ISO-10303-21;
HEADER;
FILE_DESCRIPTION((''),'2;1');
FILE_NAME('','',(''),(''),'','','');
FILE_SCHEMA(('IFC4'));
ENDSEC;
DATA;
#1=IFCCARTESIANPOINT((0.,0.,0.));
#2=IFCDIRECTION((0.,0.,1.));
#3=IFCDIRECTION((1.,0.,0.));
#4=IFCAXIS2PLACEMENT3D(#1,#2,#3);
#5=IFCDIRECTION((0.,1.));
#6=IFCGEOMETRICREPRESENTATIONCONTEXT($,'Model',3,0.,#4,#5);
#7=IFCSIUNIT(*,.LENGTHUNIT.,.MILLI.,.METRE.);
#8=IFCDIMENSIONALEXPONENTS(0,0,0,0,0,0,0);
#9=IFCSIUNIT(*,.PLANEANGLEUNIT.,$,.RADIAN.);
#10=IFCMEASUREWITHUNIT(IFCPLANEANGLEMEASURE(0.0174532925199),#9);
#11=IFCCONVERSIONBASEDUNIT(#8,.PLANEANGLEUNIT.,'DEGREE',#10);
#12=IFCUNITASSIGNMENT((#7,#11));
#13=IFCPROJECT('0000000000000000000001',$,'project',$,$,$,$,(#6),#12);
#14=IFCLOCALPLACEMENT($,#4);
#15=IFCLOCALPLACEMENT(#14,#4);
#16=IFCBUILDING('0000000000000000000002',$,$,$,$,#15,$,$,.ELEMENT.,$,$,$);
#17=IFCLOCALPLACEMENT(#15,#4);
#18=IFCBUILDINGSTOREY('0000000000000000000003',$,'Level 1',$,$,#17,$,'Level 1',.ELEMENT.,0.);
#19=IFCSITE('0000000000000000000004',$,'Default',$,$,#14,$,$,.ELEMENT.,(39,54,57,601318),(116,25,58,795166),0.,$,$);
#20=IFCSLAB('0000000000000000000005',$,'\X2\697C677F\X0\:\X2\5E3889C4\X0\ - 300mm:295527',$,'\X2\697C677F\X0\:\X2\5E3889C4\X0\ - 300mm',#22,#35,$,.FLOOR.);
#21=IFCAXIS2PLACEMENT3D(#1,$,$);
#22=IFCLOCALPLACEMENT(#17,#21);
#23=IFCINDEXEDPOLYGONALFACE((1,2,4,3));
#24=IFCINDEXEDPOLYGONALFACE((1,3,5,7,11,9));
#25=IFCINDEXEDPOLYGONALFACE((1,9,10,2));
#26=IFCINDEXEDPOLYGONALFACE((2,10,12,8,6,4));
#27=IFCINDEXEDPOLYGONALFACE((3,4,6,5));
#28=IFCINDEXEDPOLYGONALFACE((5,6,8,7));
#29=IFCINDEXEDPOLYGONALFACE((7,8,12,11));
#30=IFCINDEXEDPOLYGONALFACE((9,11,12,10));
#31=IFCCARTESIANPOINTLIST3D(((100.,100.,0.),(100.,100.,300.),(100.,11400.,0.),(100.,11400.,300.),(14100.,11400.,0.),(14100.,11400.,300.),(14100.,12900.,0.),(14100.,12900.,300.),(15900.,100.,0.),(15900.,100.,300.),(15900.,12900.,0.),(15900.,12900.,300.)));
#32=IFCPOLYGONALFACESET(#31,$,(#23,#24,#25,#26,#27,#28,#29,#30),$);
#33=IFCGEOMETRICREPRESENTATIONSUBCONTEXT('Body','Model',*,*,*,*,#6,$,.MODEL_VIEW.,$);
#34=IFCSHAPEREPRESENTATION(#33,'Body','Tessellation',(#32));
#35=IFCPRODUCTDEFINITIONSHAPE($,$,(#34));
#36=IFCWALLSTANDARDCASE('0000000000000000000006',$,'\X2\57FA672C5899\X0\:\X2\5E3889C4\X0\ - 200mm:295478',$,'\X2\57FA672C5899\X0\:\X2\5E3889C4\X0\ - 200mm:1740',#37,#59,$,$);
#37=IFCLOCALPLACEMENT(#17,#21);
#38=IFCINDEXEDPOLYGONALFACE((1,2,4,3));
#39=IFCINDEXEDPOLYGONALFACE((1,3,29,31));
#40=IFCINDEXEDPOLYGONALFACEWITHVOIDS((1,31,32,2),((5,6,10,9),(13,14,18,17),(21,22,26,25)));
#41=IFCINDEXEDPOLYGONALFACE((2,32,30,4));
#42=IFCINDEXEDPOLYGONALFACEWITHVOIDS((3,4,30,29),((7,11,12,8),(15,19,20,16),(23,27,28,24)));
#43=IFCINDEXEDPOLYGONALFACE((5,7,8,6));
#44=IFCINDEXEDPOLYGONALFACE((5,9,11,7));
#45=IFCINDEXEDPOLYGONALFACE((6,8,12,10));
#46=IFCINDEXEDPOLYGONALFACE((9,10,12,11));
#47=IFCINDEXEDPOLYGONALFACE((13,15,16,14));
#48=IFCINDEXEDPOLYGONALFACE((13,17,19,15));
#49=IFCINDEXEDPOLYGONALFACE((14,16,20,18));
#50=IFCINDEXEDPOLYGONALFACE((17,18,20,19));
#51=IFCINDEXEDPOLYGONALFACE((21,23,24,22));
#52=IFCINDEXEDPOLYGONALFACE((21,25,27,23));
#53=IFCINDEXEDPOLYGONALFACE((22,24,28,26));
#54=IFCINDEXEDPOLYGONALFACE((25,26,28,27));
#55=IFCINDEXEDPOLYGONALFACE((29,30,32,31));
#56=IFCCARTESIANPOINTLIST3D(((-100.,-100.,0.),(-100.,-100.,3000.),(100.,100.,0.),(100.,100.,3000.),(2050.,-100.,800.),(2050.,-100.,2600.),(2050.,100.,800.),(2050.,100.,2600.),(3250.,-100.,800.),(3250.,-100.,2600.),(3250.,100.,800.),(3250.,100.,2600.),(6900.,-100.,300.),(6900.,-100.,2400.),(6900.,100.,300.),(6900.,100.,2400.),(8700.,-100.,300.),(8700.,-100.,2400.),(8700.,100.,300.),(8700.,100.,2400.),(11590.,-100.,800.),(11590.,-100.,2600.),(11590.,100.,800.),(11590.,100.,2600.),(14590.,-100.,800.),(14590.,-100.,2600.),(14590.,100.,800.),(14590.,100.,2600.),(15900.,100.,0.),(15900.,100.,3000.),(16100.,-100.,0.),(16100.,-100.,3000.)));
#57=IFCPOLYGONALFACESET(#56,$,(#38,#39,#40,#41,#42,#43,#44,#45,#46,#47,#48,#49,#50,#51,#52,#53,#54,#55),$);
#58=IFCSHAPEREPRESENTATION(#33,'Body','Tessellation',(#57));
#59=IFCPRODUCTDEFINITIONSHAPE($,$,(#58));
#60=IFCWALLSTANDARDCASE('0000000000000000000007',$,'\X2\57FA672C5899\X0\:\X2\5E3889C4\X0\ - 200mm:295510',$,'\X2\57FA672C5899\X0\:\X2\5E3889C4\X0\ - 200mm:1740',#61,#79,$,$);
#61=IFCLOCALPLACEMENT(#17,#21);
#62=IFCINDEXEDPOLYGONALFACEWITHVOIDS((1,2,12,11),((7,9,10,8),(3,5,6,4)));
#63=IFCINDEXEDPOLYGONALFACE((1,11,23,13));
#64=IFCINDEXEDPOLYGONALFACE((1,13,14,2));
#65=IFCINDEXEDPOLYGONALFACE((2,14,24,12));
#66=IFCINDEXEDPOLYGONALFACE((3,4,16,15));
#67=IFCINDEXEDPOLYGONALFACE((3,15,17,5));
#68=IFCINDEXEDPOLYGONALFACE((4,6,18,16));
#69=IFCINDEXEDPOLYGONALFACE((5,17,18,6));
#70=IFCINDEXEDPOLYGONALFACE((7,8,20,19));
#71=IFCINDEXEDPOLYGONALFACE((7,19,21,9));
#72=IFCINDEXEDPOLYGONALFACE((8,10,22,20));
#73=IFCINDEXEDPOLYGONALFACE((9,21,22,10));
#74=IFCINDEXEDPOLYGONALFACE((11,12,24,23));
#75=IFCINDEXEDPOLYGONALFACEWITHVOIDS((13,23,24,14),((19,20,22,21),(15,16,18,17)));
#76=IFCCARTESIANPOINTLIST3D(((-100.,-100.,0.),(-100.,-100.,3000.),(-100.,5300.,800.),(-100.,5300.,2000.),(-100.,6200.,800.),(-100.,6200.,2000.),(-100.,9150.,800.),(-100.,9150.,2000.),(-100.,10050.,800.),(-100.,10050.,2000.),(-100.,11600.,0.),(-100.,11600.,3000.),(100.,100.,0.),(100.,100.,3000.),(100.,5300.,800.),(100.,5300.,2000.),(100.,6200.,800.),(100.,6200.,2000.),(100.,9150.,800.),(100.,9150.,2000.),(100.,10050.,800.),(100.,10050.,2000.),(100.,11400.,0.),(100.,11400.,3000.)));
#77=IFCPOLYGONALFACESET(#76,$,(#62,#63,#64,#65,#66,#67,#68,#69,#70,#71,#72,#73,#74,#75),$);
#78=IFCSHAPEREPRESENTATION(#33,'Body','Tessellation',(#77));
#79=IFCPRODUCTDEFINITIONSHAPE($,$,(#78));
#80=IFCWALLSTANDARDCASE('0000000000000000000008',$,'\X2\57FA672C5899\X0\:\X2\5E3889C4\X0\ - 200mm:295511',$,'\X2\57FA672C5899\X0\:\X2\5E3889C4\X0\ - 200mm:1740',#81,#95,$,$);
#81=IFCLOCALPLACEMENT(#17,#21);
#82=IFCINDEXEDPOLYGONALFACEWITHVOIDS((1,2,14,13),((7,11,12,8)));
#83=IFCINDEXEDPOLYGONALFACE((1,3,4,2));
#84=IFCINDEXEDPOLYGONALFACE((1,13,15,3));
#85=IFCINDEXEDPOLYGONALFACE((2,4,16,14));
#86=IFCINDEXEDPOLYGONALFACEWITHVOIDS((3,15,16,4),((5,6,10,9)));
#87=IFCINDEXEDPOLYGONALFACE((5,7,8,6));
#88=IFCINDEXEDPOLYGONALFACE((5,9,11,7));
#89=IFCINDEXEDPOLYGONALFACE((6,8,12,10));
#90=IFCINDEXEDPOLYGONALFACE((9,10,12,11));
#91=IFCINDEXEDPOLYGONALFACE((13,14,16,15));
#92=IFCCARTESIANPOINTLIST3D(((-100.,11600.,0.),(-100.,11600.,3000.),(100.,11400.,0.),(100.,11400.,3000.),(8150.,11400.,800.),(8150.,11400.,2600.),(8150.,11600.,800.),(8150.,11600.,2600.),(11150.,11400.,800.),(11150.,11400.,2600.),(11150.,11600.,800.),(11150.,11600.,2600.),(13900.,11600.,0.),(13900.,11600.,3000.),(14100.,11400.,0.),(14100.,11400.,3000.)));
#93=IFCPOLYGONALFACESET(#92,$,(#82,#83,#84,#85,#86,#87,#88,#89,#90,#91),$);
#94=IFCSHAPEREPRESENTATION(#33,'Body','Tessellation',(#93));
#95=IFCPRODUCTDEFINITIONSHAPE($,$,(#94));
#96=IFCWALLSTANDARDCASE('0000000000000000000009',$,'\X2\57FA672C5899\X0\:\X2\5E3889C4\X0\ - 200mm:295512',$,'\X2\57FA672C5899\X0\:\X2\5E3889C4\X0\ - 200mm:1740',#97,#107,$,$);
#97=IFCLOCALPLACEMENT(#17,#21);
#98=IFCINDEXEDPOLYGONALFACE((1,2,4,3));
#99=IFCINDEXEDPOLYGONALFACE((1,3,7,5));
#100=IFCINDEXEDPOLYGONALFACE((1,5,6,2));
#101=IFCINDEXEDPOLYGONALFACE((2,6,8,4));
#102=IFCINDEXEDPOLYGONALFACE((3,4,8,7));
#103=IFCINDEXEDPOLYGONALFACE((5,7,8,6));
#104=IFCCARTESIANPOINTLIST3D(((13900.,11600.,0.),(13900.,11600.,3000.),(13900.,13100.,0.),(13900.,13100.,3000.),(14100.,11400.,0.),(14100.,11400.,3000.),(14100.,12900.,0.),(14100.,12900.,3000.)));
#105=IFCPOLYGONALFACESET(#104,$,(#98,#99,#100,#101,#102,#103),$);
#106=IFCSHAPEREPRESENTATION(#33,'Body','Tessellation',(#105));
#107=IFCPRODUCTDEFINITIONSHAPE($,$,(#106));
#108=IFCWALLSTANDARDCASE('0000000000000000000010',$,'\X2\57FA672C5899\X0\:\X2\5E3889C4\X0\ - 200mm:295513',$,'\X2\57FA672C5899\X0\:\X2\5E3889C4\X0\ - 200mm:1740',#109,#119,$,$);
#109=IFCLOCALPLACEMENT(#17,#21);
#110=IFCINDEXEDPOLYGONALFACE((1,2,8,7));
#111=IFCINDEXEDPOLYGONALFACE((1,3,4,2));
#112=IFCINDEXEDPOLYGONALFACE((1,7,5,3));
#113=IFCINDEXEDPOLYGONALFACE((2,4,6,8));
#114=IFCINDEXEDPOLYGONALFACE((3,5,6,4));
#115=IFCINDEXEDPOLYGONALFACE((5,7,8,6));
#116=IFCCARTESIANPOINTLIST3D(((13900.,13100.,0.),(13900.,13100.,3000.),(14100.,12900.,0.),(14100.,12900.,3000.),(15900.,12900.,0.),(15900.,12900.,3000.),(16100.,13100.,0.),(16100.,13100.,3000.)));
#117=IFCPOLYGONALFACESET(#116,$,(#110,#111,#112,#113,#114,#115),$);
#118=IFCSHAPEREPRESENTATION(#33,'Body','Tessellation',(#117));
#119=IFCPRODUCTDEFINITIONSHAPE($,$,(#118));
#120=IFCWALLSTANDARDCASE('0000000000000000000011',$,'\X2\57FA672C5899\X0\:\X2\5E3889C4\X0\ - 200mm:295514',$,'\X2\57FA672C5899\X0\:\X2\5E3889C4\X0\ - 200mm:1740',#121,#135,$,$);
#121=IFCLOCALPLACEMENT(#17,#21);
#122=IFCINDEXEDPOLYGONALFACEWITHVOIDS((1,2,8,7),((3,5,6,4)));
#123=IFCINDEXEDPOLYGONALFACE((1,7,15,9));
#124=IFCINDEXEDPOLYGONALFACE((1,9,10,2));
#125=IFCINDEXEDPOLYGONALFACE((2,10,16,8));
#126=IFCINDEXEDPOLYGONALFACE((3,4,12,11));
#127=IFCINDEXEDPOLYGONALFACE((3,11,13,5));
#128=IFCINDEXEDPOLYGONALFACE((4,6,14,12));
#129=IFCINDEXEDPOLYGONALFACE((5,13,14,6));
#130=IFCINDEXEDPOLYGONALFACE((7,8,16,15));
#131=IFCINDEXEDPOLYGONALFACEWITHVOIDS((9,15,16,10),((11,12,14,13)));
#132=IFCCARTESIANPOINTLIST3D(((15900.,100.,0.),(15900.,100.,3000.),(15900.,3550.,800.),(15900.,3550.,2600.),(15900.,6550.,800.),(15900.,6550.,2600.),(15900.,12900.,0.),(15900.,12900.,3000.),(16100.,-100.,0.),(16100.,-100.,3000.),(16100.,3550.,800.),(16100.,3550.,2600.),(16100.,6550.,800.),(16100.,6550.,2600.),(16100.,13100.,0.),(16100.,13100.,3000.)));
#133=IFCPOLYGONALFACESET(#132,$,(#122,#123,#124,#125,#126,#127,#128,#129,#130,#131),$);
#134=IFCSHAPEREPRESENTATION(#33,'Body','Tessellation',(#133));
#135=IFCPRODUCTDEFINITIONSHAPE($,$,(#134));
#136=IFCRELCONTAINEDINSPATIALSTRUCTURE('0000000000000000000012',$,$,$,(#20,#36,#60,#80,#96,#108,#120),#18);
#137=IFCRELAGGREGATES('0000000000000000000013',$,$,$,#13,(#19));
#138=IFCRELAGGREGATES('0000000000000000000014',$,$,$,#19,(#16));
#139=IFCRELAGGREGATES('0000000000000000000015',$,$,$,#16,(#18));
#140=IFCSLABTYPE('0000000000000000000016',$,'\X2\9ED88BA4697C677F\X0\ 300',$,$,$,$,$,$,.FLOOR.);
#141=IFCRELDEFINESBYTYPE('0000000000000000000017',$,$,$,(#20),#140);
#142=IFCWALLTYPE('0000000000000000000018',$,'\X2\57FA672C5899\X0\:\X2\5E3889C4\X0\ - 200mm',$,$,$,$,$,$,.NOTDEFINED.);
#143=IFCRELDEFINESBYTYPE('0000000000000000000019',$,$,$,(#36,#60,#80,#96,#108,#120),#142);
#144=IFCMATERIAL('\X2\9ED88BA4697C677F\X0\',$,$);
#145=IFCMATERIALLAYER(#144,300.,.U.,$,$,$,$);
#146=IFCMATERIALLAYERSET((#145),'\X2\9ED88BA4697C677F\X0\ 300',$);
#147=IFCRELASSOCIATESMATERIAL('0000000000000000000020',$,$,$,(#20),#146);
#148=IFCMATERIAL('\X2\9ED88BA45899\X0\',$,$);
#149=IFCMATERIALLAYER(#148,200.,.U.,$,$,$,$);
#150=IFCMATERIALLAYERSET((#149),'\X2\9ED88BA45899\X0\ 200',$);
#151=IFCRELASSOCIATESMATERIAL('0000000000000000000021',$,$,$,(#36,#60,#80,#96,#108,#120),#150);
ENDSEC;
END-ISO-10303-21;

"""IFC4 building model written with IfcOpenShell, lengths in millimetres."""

from ifc_helpers import new_model, entity, si_unit, converted_unit, direction, frame, origin_with_axes, place, context, subcontext, project, spatial, polyline, outline, extrude, material, layer, layer_set, layer_usage, type_object, element, save


model = new_model("IFC4")

# Units and contexts
model_context = context("Model", 3, precision=0.0, world=origin_with_axes(), true_north=direction((0.0, 1.0)))
body_context = subcontext(model_context, "Body", "Model", "MODEL_VIEW")
ifc_project = project(units=[si_unit("LENGTHUNIT", "METRE", prefix="MILLI"), converted_unit("PLANEANGLEUNIT", "DEGREE", entity("IfcPlaneAngleMeasure", 0.0174532925199), si_unit("PLANEANGLEUNIT", "RADIAN"), dimensions=[0, 0, 0, 0, 0, 0, 0])], contexts=[model_context])

# Site, building, storey
site_placement = place(None, origin_with_axes())
site = spatial("IfcSite", under=ifc_project, at=site_placement, Name="Default", CompositionType="ELEMENT", RefLatitude=(39, 54, 57, 601318), RefLongitude=(116, 25, 58, 795166), RefElevation=0.0)
building_placement = place(site_placement, origin_with_axes())
building = spatial("IfcBuilding", under=site, at=building_placement, CompositionType="ELEMENT")
storey_placement = place(building_placement, origin_with_axes())
storey = spatial("IfcBuildingStorey", under=building, at=storey_placement, Name="Level 1", LongName="Level 1", CompositionType="ELEMENT", Elevation=0.0)

# Slab
ifc_material_1 = material(Name="默认楼板")
ifc_layer_1 = layer(ifc_material_1, 300.0, ventilated="UNKNOWN")
ifc_layer_set_1 = layer_set([ifc_layer_1], Name="默认楼板 300")
ifc_layer_usage_1 = layer_usage(ifc_layer_set_1, "AXIS3", "NEGATIVE", 300.0)
slab_type = type_object("IfcSlabType", Name="默认楼板 300", PredefinedType="FLOOR")
slab_placement = place(storey_placement, frame((100.0, 100.0, 0.0), z_axis=(0.0, 0.0, 1.0), x_axis=(1.0, 0.0, 0.0)))
element("IfcSlab", 1, at=slab_placement, inside=storey, type_object=slab_type, material=ifc_layer_usage_1, Name="楼板:常规 - 300mm:295527", ObjectType="楼板:常规 - 300mm", PredefinedType="FLOOR", context=body_context, shape_type="SweptSolid", body=[
    extrude(outline(polyline([(0.0, 0.0), (15800.0, 0.0), (15800.0, 12800.0), (14000.0, 12800.0), (14000.0, 11300.0), (0.0, 11300.0), (0.0, 0.0)])), origin_with_axes(), (0.0, 0.0, 1.0), 300.0),
])

# Walls, openings
ifc_material_2 = material(Name="默认墙")
ifc_layer_2 = layer(ifc_material_2, 200.0, ventilated="UNKNOWN")
ifc_layer_set_2 = layer_set([ifc_layer_2], Name="默认墙 200")
ifc_layer_usage_2 = layer_usage(ifc_layer_set_2, "AXIS2", "POSITIVE", -100.0)
wall_type = type_object("IfcWallType", Name="基本墙:常规 - 200mm", PredefinedType="NOTDEFINED")
wall_1_placement = place(storey_placement, frame((16000.0, 0.0, 0.0), z_axis=(0.0, 0.0, 1.0), x_axis=(-1.0, 0.0, 0.0)))
wall_1 = element("IfcWallStandardCase", 2, at=wall_1_placement, inside=storey, type_object=wall_type, material=ifc_layer_usage_2, Name="基本墙:常规 - 200mm:295478", ObjectType="基本墙:常规 - 200mm:1740", context=body_context, shape_type="SweptSolid", body=[
    extrude(outline(polyline([(100.0, -100.0), (15900.0, -100.0), (16100.0, 100.0), (-100.0, 100.0), (100.0, -100.0)])), origin_with_axes(), (0.0, 0.0, 1.0), 3000.0),
])
opening_1_placement = place(wall_1_placement, frame((13350.0, 0.0, 800.0), z_axis=(0.0, 0.0, 1.0), x_axis=(1.0, 0.0, 0.0)))
element("IfcOpeningElement", 3, at=opening_1_placement, cuts=wall_1, context=body_context, shape_type="SweptSolid", body=[
    extrude(outline(polyline([(-600.0, 0.0), (-600.0, -1800.0), (600.0, -1800.0), (600.0, 0.0), (-600.0, 0.0)])), frame((0.0, -100.0, 0.0), z_axis=(0.0, 1.0, 0.0), x_axis=(1.0, 0.0, 0.0)), (0.0, 0.0, 1.0), 200.0),
])
opening_2_placement = place(wall_1_placement, frame((2910.0, 0.0, 800.0), z_axis=(0.0, 0.0, 1.0), x_axis=(1.0, 0.0, 0.0)))
element("IfcOpeningElement", 4, at=opening_2_placement, cuts=wall_1, context=body_context, shape_type="SweptSolid", body=[
    extrude(outline(polyline([(-1500.0, 0.0), (-1500.0, -1800.0), (1500.0, -1800.0), (1500.0, 0.0), (-1500.0, 0.0)])), frame((0.0, -100.0, 0.0), z_axis=(0.0, 1.0, 0.0), x_axis=(1.0, 0.0, 0.0)), (0.0, 0.0, 1.0), 200.0),
])
opening_3_placement = place(wall_1_placement, frame((8200.0, 0.0, 300.0), z_axis=(0.0, 0.0, 1.0), x_axis=(1.0, 0.0, 0.0)))
element("IfcOpeningElement", 5, at=opening_3_placement, cuts=wall_1, context=body_context, shape_type="SweptSolid", body=[
    extrude(outline(polyline([(-900.0, 0.0), (-900.0, -2100.0), (900.0, -2100.0), (900.0, 0.0), (-900.0, 0.0)])), frame((0.0, -100.0, 0.0), z_axis=(0.0, 1.0, 0.0), x_axis=(1.0, 0.0, 0.0)), (0.0, 0.0, 1.0), 200.0),
])
ifc_layer_usage_3 = layer_usage(ifc_layer_set_2, "AXIS2", "POSITIVE", -100.0)
wall_2_placement = place(storey_placement, frame((0.0, 0.0, 0.0), z_axis=(0.0, 0.0, 1.0), x_axis=(0.0, 1.0, 0.0)))
wall_2 = element("IfcWallStandardCase", 6, at=wall_2_placement, inside=storey, type_object=wall_type, material=ifc_layer_usage_3, Name="基本墙:常规 - 200mm:295510", ObjectType="基本墙:常规 - 200mm:1740", context=body_context, shape_type="SweptSolid", body=[
    extrude(outline(polyline([(100.0, -100.0), (11400.0, -100.0), (11600.0, 100.0), (-100.0, 100.0), (100.0, -100.0)])), origin_with_axes(), (0.0, 0.0, 1.0), 3000.0),
])
opening_4_placement = place(wall_2_placement, frame((5750.0, 0.0, 800.0), z_axis=(0.0, 0.0, 1.0), x_axis=(1.0, 0.0, 0.0)))
element("IfcOpeningElement", 7, at=opening_4_placement, cuts=wall_2, context=body_context, shape_type="SweptSolid", body=[
    extrude(outline(polyline([(450.0, -1200.0), (450.0, 0.0), (-450.0, 0.0), (-450.0, -1200.0), (450.0, -1200.0)])), frame((0.0, 100.0, 0.0), z_axis=(0.0, -1.0, 0.0), x_axis=(-1.0, 0.0, 0.0)), (0.0, 0.0, 1.0), 200.0),
])
opening_5_placement = place(wall_2_placement, frame((9600.0, 0.0, 800.0), z_axis=(0.0, 0.0, 1.0), x_axis=(1.0, 0.0, 0.0)))
element("IfcOpeningElement", 8, at=opening_5_placement, cuts=wall_2, context=body_context, shape_type="SweptSolid", body=[
    extrude(outline(polyline([(450.0, -1200.0), (450.0, 0.0), (-450.0, 0.0), (-450.0, -1200.0), (450.0, -1200.0)])), frame((0.0, 100.0, 0.0), z_axis=(0.0, -1.0, 0.0), x_axis=(-1.0, 0.0, 0.0)), (0.0, 0.0, 1.0), 200.0),
])

# Wall, opening
ifc_layer_usage_4 = layer_usage(ifc_layer_set_2, "AXIS2", "POSITIVE", -100.0)
wall_3_placement = place(storey_placement, frame((0.0, 11500.0, 0.0), z_axis=(0.0, 0.0, 1.0), x_axis=(1.0, 0.0, 0.0)))
wall_3 = element("IfcWallStandardCase", 9, at=wall_3_placement, inside=storey, type_object=wall_type, material=ifc_layer_usage_4, Name="基本墙:常规 - 200mm:295511", ObjectType="基本墙:常规 - 200mm:1740", context=body_context, shape_type="SweptSolid", body=[
    extrude(outline(polyline([(100.0, -100.0), (14100.0, -100.0), (13900.0, 100.0), (-100.0, 100.0), (100.0, -100.0)])), origin_with_axes(), (0.0, 0.0, 1.0), 3000.0),
])
opening_6_placement = place(wall_3_placement, frame((9650.0, 0.0, 800.0), z_axis=(0.0, 0.0, 1.0), x_axis=(1.0, 0.0, 0.0)))
element("IfcOpeningElement", 10, at=opening_6_placement, cuts=wall_3, context=body_context, shape_type="SweptSolid", body=[
    extrude(outline(polyline([(-1500.0, 0.0), (-1500.0, -1800.0), (1500.0, -1800.0), (1500.0, 0.0), (-1500.0, 0.0)])), frame((0.0, -100.0, 0.0), z_axis=(0.0, 1.0, 0.0), x_axis=(1.0, 0.0, 0.0)), (0.0, 0.0, 1.0), 200.0),
])

# Walls
ifc_layer_usage_5 = layer_usage(ifc_layer_set_2, "AXIS2", "POSITIVE", -100.0)
wall_4_placement = place(storey_placement, frame((14000.0, 11500.0, 0.0), z_axis=(0.0, 0.0, 1.0), x_axis=(0.0, 1.0, 0.0)))
element("IfcWallStandardCase", 11, at=wall_4_placement, inside=storey, type_object=wall_type, material=ifc_layer_usage_5, Name="基本墙:常规 - 200mm:295512", ObjectType="基本墙:常规 - 200mm:1740", context=body_context, shape_type="SweptSolid", body=[
    extrude(outline(polyline([(-100.0, -100.0), (1400.0, -100.0), (1600.0, 100.0), (100.0, 100.0), (-100.0, -100.0)])), origin_with_axes(), (0.0, 0.0, 1.0), 3000.0),
])
ifc_layer_usage_6 = layer_usage(ifc_layer_set_2, "AXIS2", "POSITIVE", -100.0)
wall_5_placement = place(storey_placement, frame((14000.0, 13000.0, 0.0), z_axis=(0.0, 0.0, 1.0), x_axis=(1.0, 0.0, 0.0)))
element("IfcWallStandardCase", 12, at=wall_5_placement, inside=storey, type_object=wall_type, material=ifc_layer_usage_6, Name="基本墙:常规 - 200mm:295513", ObjectType="基本墙:常规 - 200mm:1740", context=body_context, shape_type="SweptSolid", body=[
    extrude(outline(polyline([(100.0, -100.0), (1900.0, -100.0), (2100.0, 100.0), (-100.0, 100.0), (100.0, -100.0)])), origin_with_axes(), (0.0, 0.0, 1.0), 3000.0),
])

# Wall, opening
ifc_layer_usage_7 = layer_usage(ifc_layer_set_2, "AXIS2", "POSITIVE", -100.0)
wall_6_placement = place(storey_placement, frame((16000.0, 13000.0, 0.0), z_axis=(0.0, 0.0, 1.0), x_axis=(0.0, -1.0, 0.0)))
wall_6 = element("IfcWallStandardCase", 13, at=wall_6_placement, inside=storey, type_object=wall_type, material=ifc_layer_usage_7, Name="基本墙:常规 - 200mm:295514", ObjectType="基本墙:常规 - 200mm:1740", context=body_context, shape_type="SweptSolid", body=[
    extrude(outline(polyline([(100.0, -100.0), (12900.0, -100.0), (13100.0, 100.0), (-100.0, 100.0), (100.0, -100.0)])), origin_with_axes(), (0.0, 0.0, 1.0), 3000.0),
])
opening_7_placement = place(wall_6_placement, frame((7950.0, 0.0, 800.0), z_axis=(0.0, 0.0, 1.0), x_axis=(1.0, 0.0, 0.0)))
element("IfcOpeningElement", 14, at=opening_7_placement, cuts=wall_6, context=body_context, shape_type="SweptSolid", body=[
    extrude(outline(polyline([(-1500.0, 0.0), (-1500.0, -1800.0), (1500.0, -1800.0), (1500.0, 0.0), (-1500.0, 0.0)])), frame((0.0, -100.0, 0.0), z_axis=(0.0, 1.0, 0.0), x_axis=(1.0, 0.0, 0.0)), (0.0, 0.0, 1.0), 200.0),
])

save(model, "model.ifc")
